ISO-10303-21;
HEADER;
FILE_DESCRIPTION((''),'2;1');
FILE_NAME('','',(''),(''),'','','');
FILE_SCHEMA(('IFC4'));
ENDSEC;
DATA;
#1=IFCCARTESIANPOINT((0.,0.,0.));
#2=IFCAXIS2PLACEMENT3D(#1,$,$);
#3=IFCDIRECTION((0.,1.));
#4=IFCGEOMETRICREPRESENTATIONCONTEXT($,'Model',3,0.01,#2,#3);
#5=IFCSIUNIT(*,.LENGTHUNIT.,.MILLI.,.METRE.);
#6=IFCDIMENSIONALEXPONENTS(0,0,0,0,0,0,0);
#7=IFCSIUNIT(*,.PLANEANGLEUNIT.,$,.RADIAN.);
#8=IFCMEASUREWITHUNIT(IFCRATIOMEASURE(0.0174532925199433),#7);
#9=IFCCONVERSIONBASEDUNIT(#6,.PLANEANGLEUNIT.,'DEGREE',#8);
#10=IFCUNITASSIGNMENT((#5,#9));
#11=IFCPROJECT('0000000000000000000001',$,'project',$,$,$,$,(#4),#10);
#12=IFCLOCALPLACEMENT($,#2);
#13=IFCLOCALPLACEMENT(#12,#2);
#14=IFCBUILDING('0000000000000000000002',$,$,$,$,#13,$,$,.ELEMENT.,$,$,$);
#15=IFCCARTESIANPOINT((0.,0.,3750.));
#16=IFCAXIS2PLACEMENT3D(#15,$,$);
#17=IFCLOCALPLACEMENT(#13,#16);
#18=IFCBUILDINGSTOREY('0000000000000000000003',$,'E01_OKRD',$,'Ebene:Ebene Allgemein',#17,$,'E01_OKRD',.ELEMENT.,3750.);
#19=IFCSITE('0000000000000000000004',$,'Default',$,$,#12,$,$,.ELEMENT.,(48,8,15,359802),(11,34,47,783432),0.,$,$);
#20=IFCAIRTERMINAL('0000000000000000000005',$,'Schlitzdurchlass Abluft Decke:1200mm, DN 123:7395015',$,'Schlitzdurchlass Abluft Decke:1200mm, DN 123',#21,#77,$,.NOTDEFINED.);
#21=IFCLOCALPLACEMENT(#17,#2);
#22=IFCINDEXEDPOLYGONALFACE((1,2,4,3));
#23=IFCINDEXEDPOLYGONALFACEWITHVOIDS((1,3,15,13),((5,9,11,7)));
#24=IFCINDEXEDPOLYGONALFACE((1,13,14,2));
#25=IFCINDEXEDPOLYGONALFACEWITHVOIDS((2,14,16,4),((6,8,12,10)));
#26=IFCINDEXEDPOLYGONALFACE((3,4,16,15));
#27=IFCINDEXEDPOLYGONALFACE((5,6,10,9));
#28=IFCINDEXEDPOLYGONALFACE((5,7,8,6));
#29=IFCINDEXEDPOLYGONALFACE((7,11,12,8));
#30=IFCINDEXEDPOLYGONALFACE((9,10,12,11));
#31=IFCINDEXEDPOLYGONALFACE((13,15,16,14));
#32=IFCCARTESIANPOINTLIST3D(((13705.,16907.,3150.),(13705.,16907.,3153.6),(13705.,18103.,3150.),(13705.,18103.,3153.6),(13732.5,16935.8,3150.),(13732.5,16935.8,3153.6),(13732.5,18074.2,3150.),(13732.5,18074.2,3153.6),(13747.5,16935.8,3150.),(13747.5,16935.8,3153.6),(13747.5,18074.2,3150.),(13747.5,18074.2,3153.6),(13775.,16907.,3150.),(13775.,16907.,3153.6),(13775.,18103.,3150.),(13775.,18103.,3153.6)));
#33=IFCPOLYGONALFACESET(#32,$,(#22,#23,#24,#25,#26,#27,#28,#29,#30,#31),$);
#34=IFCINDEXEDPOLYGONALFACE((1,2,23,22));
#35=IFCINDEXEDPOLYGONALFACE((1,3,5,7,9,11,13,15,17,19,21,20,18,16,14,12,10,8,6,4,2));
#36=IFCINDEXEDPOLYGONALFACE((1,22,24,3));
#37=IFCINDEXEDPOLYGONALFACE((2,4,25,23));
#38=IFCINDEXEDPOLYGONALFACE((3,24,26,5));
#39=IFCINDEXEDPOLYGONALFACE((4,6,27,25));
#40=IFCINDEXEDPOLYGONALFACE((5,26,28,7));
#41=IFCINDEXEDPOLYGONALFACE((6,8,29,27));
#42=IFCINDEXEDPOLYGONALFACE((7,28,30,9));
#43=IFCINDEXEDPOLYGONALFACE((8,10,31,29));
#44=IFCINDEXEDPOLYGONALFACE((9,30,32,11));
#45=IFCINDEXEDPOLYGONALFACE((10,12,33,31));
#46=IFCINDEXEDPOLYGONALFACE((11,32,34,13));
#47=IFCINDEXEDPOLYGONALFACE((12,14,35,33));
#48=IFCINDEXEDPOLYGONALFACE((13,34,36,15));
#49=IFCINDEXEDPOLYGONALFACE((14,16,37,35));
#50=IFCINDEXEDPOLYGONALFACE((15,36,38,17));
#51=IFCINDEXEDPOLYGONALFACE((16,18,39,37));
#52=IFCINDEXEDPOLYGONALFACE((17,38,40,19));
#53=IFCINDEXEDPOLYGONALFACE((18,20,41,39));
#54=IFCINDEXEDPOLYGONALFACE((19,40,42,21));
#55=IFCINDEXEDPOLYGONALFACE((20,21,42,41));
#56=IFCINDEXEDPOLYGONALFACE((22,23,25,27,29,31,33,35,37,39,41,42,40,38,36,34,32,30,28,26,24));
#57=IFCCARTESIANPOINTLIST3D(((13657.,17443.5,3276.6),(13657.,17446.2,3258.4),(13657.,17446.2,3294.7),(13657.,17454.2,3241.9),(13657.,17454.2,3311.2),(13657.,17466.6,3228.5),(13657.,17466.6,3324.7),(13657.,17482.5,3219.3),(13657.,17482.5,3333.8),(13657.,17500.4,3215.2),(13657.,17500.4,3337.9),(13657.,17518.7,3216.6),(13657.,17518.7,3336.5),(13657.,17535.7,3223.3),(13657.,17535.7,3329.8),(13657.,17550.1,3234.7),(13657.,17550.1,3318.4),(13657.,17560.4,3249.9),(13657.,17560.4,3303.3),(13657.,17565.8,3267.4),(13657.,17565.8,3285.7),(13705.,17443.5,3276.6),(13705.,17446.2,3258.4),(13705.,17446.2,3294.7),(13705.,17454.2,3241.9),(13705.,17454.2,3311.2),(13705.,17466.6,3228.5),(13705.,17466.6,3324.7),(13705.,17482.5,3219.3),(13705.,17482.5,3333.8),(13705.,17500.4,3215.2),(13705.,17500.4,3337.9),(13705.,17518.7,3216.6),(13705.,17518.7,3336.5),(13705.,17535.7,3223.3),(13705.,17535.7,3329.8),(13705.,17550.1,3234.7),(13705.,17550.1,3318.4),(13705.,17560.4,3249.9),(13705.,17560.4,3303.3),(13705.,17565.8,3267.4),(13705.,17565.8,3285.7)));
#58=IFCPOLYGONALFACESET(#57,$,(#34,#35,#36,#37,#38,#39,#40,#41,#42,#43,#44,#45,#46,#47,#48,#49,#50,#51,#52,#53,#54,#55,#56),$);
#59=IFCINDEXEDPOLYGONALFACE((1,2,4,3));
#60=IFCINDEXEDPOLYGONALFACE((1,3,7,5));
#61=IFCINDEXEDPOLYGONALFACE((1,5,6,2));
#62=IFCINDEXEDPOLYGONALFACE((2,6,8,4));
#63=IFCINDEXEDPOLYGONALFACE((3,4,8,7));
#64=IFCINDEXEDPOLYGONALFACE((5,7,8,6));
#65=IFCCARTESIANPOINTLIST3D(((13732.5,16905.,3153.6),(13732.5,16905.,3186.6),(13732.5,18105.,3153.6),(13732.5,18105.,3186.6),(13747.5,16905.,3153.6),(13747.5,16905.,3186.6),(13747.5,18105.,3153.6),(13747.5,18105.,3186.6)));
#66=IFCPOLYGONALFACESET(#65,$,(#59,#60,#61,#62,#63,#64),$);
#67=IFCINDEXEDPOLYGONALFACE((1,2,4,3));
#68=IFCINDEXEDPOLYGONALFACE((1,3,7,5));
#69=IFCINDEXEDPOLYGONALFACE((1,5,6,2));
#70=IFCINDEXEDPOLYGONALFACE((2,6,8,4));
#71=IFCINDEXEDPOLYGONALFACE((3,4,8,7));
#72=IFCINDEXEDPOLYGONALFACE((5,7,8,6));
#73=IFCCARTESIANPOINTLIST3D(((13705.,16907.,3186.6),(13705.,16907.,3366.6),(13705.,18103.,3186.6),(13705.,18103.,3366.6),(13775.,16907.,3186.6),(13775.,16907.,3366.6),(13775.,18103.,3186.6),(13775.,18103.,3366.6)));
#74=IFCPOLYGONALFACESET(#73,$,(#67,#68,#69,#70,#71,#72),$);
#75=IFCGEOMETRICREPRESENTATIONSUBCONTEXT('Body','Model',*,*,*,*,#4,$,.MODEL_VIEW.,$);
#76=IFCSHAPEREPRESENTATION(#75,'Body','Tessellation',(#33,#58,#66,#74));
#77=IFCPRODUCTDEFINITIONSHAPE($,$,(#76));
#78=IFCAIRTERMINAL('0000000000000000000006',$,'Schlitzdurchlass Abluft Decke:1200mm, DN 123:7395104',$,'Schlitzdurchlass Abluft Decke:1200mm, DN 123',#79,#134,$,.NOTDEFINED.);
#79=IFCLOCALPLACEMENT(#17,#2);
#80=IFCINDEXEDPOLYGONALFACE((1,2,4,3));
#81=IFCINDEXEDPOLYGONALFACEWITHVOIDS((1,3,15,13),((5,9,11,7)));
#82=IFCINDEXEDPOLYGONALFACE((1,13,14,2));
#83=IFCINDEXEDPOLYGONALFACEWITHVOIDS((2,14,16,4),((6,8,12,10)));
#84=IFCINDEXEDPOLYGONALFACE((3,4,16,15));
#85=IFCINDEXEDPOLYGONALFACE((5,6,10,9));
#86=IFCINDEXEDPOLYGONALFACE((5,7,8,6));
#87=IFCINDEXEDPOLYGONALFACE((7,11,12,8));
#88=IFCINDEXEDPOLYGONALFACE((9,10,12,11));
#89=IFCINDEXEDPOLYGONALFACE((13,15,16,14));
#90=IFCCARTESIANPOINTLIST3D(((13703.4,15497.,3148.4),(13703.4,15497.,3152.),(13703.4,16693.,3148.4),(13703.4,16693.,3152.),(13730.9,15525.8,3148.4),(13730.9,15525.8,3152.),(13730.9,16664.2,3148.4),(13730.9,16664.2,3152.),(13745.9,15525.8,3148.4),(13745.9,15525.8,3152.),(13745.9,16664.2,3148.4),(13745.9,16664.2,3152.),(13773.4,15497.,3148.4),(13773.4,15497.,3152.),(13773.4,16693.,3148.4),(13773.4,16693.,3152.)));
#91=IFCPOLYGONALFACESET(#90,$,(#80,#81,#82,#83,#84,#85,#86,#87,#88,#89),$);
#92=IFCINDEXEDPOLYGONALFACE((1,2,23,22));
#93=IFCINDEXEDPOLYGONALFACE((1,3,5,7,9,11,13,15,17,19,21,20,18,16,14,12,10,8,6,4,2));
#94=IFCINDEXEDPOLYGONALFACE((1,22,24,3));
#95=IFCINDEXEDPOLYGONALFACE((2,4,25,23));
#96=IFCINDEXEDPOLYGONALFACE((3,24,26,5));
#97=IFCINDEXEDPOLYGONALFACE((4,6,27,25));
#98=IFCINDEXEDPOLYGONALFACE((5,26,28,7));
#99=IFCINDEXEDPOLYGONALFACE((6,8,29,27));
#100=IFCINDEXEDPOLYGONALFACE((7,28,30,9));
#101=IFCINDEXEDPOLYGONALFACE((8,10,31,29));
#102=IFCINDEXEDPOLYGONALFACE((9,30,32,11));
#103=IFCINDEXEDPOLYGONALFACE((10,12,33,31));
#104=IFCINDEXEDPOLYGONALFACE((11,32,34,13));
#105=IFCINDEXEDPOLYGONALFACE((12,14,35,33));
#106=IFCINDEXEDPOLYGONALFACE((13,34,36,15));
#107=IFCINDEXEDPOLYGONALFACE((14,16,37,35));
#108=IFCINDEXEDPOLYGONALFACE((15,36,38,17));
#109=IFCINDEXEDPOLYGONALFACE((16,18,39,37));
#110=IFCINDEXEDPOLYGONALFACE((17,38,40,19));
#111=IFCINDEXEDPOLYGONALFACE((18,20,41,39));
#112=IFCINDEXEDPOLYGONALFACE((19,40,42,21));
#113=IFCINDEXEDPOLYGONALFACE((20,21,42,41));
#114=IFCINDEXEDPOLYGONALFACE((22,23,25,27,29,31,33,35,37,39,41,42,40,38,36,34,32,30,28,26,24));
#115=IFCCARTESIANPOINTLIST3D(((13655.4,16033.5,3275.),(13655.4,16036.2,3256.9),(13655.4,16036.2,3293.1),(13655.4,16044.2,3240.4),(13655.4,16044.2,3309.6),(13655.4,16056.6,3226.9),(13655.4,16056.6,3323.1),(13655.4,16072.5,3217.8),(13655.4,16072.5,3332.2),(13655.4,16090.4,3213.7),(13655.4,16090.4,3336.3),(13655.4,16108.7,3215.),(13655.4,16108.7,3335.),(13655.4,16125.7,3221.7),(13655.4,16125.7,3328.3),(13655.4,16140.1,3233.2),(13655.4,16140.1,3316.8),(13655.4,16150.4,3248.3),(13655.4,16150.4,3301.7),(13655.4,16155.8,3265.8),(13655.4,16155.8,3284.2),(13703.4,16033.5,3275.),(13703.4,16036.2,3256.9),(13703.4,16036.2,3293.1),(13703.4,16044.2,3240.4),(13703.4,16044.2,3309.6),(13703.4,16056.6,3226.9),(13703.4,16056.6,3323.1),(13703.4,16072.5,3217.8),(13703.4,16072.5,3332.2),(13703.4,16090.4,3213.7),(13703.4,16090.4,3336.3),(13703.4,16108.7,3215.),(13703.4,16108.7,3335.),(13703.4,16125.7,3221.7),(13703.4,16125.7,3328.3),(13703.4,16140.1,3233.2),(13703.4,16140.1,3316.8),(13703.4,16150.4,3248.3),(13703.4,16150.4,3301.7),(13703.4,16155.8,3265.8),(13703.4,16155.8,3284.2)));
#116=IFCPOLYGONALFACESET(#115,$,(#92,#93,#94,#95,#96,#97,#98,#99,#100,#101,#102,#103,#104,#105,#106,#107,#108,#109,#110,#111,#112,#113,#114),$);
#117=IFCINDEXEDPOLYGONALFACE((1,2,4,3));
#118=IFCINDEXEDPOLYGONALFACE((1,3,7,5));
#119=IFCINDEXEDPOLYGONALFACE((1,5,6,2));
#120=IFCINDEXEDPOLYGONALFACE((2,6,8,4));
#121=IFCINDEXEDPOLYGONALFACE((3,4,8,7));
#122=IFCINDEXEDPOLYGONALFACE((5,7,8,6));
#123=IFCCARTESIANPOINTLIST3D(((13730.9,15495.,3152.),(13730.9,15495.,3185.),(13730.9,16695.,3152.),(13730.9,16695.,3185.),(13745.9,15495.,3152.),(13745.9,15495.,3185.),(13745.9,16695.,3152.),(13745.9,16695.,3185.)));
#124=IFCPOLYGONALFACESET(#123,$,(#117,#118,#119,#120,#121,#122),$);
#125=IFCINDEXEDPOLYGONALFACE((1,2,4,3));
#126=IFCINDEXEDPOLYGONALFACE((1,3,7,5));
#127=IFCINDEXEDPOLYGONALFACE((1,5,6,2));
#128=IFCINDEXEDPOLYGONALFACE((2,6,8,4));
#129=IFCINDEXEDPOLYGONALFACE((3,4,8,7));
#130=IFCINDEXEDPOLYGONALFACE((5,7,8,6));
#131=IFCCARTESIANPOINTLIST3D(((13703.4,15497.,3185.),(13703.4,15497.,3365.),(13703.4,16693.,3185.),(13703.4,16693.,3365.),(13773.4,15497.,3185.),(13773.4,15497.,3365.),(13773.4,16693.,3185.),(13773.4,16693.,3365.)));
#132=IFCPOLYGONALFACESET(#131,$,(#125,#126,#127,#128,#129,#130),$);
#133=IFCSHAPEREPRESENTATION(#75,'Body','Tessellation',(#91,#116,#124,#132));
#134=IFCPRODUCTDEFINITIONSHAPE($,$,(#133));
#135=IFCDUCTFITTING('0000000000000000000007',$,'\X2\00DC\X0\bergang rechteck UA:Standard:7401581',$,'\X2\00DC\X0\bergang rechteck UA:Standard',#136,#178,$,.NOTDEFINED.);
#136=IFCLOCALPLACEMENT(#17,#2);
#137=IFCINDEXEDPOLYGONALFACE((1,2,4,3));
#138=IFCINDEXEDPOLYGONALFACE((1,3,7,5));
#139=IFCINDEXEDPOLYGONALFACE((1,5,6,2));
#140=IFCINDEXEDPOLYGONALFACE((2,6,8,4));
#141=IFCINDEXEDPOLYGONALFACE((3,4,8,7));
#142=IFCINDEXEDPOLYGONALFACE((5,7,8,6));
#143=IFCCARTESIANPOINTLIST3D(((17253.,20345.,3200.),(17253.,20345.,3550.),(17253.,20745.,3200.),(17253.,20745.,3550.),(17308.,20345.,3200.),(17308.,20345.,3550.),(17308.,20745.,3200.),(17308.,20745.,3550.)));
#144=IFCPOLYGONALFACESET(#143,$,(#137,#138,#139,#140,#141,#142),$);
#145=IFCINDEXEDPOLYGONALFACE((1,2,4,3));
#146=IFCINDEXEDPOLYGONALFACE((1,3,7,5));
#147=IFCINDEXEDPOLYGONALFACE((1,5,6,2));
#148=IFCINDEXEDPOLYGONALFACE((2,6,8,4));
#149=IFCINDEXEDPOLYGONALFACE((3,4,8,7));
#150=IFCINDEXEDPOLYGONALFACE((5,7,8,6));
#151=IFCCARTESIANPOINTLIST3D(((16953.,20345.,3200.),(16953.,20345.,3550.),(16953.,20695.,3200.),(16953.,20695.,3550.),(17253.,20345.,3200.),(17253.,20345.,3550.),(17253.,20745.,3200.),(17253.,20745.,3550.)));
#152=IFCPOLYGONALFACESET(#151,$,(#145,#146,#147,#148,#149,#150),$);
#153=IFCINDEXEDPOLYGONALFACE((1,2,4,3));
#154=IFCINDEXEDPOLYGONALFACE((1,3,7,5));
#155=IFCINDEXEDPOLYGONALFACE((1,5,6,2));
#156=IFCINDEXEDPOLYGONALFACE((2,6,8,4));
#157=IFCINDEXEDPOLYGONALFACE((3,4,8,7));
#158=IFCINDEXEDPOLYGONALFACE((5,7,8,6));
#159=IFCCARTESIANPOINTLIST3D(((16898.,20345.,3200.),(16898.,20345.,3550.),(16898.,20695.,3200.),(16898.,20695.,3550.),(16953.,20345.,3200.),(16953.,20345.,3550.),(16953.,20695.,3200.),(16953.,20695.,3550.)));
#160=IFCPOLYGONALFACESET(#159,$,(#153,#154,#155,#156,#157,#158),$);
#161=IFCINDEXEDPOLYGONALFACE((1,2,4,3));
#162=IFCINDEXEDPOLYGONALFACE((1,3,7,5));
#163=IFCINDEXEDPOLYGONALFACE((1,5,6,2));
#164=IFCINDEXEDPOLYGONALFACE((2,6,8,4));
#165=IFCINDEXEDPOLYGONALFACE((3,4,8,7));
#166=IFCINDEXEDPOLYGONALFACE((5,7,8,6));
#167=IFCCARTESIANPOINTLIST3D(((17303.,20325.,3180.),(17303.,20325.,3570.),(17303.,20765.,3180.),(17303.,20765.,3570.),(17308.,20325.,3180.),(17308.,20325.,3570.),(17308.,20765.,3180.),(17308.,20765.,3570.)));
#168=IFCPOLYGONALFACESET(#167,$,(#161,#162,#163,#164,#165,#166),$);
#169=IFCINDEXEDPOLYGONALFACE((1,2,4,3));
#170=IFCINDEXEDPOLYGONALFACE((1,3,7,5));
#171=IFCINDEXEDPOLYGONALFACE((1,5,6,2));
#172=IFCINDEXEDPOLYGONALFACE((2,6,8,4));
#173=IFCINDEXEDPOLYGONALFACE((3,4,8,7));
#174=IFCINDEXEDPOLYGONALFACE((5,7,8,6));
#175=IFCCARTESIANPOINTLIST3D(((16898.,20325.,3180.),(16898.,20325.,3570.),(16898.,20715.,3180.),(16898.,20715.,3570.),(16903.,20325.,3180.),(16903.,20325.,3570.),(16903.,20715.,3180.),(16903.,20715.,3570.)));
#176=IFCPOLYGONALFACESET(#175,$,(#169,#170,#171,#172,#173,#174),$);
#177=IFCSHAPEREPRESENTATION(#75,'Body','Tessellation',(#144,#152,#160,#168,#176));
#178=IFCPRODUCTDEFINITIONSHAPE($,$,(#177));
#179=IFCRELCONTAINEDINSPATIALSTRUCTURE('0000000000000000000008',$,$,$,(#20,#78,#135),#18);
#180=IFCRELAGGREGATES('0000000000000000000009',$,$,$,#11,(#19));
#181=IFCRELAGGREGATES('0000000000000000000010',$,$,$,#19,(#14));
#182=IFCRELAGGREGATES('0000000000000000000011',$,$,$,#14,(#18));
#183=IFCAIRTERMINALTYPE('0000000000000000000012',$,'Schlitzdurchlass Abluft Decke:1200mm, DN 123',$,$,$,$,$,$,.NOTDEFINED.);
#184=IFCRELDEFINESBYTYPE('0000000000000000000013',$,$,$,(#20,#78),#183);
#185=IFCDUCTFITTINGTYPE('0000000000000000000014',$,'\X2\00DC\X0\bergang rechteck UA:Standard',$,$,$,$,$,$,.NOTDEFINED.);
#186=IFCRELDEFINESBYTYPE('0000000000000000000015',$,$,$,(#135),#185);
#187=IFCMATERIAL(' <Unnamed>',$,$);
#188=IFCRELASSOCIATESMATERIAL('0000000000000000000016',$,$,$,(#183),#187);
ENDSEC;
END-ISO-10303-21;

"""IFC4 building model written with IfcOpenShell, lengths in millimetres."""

from ifc_helpers import new_model, entity, si_unit, converted_unit, direction, frame, frame_2d, origin, origin_2d_with_axis, place, context, subcontext, project, spatial, polyline, rectangle, circle, outline, extrude, source, transform, mapped, material, type_object, type_shapes, element, save


model = new_model("IFC4")

# Units and contexts
model_context = context("Model", 3, precision=0.01, world=origin(), true_north=direction((0.0, 1.0)))
body_context = subcontext(model_context, "Body", "Model", "MODEL_VIEW")
ifc_project = project(units=[si_unit("LENGTHUNIT", "METRE", prefix="MILLI"), converted_unit("PLANEANGLEUNIT", "DEGREE", entity("IfcRatioMeasure", 0.0174532925199433), si_unit("PLANEANGLEUNIT", "RADIAN"), dimensions=[0, 0, 0, 0, 0, 0, 0])], contexts=[model_context])

# Site, building, storey
site_placement = place(None, origin())
site = spatial("IfcSite", under=ifc_project, at=site_placement, Name="Default", CompositionType="ELEMENT", RefLatitude=(48, 8, 15, 359802), RefLongitude=(11, 34, 47, 783432), RefElevation=0.0)
building_placement = place(site_placement, origin())
building = spatial("IfcBuilding", under=site, at=building_placement, CompositionType="ELEMENT")
storey_placement = place(building_placement, frame((0.0, 0.0, 3750.0)))
storey = spatial("IfcBuildingStorey", under=building, at=storey_placement, Name="E01_OKRD", ObjectType="Ebene:Ebene Allgemein", LongName="E01_OKRD", CompositionType="ELEMENT", Elevation=3750.0)

# Shared definitions
ifc_material_1 = material(Name=" <Unnamed>")

# Air terminals
air_terminal_type_1 = type_object("IfcAirTerminalType", Name="Schlitzdurchlass Abluft Decke:1200mm, DN 123", PredefinedType="NOTDEFINED", material=ifc_material_1)
shared_shape_1 = source(origin(), body_context, "Body", "SweptSolid", [
    extrude(outline(polyline([(-598.0, -35.0), (598.0, -35.0), (598.0, 35.0), (-598.0, 35.0), (-598.0, -35.0)]), holes=[polyline([(-569.2, -7.5), (-569.2, 7.5), (569.2, 7.5), (569.2, -7.5), (-569.2, -7.5)])]), frame((0.0, 0.0, 0.0), z_axis=(0.0, 0.0, 1.0), x_axis=(-1.0, 0.0, 0.0)), (0.0, 0.0, 1.0), 3.6),
    extrude(circle(Radius=61.5, at=frame_2d((0.0, 0.0), x_axis=(1.0, 0.0))), frame((0.0, 35.0, 126.6), z_axis=(0.0, 1.0, 0.0), x_axis=(-1.0, 0.0, 0.0)), (0.0, 0.0, 1.0), 48.0),
    extrude(rectangle(XDim=1200.0, YDim=15.0, at=origin_2d_with_axis()), frame((0.0, 0.0, 3.6), z_axis=(0.0, 0.0, 1.0), x_axis=(-1.0, 0.0, 0.0)), (0.0, 0.0, 1.0), 33.0),
    extrude(rectangle(XDim=1196.0, YDim=70.0, at=origin_2d_with_axis()), frame((0.0, 0.0, 36.6), z_axis=(0.0, 0.0, 1.0), x_axis=(-1.0, 0.0, 0.0)), (0.0, 0.0, 1.0), 180.0),
])
type_shapes(air_terminal_type_1, [shared_shape_1])
for number, where, z_axis, x_axis, name in (
    (1, (13740.0, 17505.0, 3150.0), (0.0, 0.0, 1.0), (0.0, 1.0, 0.0), "Schlitzdurchlass Abluft Decke:1200mm, DN 123:7395015"),
    (2, (13738.4, 16095.0, 3148.4), (0.0, 0.0, 1.0), (0.0, 1.0, 0.0), "Schlitzdurchlass Abluft Decke:1200mm, DN 123:7395104"),
):
    element("IfcAirTerminal", number, at=place(storey_placement, frame(where, z_axis=z_axis, x_axis=x_axis)), inside=storey, type_object=air_terminal_type_1, Name=name, ObjectType="Schlitzdurchlass Abluft Decke:1200mm, DN 123", PredefinedType="NOTDEFINED", context=body_context, shape_type="MappedRepresentation", body=[
        mapped(shared_shape_1, transform((0.0, 0.0, 0.0), scale=1.0)),
    ])

# Duct fitting
duct_fitting_type_1 = type_object("IfcDuctFittingType", Name="Übergang rechteck UA:Standard", PredefinedType="NOTDEFINED")
shared_shape_2 = source(origin(), body_context, "Body", "SweptSolid", [
    extrude(rectangle(XDim=55.0, YDim=400.0, at=frame_2d((0.0, 0.0), x_axis=(1.0, 0.0))), frame((382.5, 25.0, -175.0)), (0.0, 0.0, 1.0), 350.0),
    extrude(outline(polyline([(-150.0, -187.5), (150.0, -187.5), (150.0, 212.5), (-150.0, 162.5), (-150.0, -187.5)])), frame((205.0, 12.5, -175.0)), (0.0, 0.0, 1.0), 350.0),
    extrude(rectangle(XDim=55.0, YDim=350.0, at=frame_2d((0.0, 0.0), x_axis=(1.0, 0.0))), frame((27.5, 0.0, -175.0)), (0.0, 0.0, 1.0), 350.0),
    extrude(rectangle(XDim=5.0, YDim=440.0, at=origin_2d_with_axis()), frame((407.5, 25.0, -195.0)), (0.0, 0.0, 1.0), 390.0),
    extrude(rectangle(XDim=5.0, YDim=390.0, at=frame_2d((0.0, 0.0), x_axis=(1.0, 0.0))), frame((2.5, 0.0, -195.0)), (0.0, 0.0, 1.0), 390.0),
])
type_shapes(duct_fitting_type_1, [shared_shape_2])
duct_fitting_1_placement = place(storey_placement, frame((16898.0, 20520.0, 3375.0)))
element("IfcDuctFitting", 3, at=duct_fitting_1_placement, inside=storey, type_object=duct_fitting_type_1, Name="Übergang rechteck UA:Standard:7401581", ObjectType="Übergang rechteck UA:Standard", PredefinedType="NOTDEFINED", context=body_context, shape_type="MappedRepresentation", body=[
    mapped(shared_shape_2, transform((0.0, 0.0, 0.0), scale=1.0)),
])

save(model, "model.ifc")
